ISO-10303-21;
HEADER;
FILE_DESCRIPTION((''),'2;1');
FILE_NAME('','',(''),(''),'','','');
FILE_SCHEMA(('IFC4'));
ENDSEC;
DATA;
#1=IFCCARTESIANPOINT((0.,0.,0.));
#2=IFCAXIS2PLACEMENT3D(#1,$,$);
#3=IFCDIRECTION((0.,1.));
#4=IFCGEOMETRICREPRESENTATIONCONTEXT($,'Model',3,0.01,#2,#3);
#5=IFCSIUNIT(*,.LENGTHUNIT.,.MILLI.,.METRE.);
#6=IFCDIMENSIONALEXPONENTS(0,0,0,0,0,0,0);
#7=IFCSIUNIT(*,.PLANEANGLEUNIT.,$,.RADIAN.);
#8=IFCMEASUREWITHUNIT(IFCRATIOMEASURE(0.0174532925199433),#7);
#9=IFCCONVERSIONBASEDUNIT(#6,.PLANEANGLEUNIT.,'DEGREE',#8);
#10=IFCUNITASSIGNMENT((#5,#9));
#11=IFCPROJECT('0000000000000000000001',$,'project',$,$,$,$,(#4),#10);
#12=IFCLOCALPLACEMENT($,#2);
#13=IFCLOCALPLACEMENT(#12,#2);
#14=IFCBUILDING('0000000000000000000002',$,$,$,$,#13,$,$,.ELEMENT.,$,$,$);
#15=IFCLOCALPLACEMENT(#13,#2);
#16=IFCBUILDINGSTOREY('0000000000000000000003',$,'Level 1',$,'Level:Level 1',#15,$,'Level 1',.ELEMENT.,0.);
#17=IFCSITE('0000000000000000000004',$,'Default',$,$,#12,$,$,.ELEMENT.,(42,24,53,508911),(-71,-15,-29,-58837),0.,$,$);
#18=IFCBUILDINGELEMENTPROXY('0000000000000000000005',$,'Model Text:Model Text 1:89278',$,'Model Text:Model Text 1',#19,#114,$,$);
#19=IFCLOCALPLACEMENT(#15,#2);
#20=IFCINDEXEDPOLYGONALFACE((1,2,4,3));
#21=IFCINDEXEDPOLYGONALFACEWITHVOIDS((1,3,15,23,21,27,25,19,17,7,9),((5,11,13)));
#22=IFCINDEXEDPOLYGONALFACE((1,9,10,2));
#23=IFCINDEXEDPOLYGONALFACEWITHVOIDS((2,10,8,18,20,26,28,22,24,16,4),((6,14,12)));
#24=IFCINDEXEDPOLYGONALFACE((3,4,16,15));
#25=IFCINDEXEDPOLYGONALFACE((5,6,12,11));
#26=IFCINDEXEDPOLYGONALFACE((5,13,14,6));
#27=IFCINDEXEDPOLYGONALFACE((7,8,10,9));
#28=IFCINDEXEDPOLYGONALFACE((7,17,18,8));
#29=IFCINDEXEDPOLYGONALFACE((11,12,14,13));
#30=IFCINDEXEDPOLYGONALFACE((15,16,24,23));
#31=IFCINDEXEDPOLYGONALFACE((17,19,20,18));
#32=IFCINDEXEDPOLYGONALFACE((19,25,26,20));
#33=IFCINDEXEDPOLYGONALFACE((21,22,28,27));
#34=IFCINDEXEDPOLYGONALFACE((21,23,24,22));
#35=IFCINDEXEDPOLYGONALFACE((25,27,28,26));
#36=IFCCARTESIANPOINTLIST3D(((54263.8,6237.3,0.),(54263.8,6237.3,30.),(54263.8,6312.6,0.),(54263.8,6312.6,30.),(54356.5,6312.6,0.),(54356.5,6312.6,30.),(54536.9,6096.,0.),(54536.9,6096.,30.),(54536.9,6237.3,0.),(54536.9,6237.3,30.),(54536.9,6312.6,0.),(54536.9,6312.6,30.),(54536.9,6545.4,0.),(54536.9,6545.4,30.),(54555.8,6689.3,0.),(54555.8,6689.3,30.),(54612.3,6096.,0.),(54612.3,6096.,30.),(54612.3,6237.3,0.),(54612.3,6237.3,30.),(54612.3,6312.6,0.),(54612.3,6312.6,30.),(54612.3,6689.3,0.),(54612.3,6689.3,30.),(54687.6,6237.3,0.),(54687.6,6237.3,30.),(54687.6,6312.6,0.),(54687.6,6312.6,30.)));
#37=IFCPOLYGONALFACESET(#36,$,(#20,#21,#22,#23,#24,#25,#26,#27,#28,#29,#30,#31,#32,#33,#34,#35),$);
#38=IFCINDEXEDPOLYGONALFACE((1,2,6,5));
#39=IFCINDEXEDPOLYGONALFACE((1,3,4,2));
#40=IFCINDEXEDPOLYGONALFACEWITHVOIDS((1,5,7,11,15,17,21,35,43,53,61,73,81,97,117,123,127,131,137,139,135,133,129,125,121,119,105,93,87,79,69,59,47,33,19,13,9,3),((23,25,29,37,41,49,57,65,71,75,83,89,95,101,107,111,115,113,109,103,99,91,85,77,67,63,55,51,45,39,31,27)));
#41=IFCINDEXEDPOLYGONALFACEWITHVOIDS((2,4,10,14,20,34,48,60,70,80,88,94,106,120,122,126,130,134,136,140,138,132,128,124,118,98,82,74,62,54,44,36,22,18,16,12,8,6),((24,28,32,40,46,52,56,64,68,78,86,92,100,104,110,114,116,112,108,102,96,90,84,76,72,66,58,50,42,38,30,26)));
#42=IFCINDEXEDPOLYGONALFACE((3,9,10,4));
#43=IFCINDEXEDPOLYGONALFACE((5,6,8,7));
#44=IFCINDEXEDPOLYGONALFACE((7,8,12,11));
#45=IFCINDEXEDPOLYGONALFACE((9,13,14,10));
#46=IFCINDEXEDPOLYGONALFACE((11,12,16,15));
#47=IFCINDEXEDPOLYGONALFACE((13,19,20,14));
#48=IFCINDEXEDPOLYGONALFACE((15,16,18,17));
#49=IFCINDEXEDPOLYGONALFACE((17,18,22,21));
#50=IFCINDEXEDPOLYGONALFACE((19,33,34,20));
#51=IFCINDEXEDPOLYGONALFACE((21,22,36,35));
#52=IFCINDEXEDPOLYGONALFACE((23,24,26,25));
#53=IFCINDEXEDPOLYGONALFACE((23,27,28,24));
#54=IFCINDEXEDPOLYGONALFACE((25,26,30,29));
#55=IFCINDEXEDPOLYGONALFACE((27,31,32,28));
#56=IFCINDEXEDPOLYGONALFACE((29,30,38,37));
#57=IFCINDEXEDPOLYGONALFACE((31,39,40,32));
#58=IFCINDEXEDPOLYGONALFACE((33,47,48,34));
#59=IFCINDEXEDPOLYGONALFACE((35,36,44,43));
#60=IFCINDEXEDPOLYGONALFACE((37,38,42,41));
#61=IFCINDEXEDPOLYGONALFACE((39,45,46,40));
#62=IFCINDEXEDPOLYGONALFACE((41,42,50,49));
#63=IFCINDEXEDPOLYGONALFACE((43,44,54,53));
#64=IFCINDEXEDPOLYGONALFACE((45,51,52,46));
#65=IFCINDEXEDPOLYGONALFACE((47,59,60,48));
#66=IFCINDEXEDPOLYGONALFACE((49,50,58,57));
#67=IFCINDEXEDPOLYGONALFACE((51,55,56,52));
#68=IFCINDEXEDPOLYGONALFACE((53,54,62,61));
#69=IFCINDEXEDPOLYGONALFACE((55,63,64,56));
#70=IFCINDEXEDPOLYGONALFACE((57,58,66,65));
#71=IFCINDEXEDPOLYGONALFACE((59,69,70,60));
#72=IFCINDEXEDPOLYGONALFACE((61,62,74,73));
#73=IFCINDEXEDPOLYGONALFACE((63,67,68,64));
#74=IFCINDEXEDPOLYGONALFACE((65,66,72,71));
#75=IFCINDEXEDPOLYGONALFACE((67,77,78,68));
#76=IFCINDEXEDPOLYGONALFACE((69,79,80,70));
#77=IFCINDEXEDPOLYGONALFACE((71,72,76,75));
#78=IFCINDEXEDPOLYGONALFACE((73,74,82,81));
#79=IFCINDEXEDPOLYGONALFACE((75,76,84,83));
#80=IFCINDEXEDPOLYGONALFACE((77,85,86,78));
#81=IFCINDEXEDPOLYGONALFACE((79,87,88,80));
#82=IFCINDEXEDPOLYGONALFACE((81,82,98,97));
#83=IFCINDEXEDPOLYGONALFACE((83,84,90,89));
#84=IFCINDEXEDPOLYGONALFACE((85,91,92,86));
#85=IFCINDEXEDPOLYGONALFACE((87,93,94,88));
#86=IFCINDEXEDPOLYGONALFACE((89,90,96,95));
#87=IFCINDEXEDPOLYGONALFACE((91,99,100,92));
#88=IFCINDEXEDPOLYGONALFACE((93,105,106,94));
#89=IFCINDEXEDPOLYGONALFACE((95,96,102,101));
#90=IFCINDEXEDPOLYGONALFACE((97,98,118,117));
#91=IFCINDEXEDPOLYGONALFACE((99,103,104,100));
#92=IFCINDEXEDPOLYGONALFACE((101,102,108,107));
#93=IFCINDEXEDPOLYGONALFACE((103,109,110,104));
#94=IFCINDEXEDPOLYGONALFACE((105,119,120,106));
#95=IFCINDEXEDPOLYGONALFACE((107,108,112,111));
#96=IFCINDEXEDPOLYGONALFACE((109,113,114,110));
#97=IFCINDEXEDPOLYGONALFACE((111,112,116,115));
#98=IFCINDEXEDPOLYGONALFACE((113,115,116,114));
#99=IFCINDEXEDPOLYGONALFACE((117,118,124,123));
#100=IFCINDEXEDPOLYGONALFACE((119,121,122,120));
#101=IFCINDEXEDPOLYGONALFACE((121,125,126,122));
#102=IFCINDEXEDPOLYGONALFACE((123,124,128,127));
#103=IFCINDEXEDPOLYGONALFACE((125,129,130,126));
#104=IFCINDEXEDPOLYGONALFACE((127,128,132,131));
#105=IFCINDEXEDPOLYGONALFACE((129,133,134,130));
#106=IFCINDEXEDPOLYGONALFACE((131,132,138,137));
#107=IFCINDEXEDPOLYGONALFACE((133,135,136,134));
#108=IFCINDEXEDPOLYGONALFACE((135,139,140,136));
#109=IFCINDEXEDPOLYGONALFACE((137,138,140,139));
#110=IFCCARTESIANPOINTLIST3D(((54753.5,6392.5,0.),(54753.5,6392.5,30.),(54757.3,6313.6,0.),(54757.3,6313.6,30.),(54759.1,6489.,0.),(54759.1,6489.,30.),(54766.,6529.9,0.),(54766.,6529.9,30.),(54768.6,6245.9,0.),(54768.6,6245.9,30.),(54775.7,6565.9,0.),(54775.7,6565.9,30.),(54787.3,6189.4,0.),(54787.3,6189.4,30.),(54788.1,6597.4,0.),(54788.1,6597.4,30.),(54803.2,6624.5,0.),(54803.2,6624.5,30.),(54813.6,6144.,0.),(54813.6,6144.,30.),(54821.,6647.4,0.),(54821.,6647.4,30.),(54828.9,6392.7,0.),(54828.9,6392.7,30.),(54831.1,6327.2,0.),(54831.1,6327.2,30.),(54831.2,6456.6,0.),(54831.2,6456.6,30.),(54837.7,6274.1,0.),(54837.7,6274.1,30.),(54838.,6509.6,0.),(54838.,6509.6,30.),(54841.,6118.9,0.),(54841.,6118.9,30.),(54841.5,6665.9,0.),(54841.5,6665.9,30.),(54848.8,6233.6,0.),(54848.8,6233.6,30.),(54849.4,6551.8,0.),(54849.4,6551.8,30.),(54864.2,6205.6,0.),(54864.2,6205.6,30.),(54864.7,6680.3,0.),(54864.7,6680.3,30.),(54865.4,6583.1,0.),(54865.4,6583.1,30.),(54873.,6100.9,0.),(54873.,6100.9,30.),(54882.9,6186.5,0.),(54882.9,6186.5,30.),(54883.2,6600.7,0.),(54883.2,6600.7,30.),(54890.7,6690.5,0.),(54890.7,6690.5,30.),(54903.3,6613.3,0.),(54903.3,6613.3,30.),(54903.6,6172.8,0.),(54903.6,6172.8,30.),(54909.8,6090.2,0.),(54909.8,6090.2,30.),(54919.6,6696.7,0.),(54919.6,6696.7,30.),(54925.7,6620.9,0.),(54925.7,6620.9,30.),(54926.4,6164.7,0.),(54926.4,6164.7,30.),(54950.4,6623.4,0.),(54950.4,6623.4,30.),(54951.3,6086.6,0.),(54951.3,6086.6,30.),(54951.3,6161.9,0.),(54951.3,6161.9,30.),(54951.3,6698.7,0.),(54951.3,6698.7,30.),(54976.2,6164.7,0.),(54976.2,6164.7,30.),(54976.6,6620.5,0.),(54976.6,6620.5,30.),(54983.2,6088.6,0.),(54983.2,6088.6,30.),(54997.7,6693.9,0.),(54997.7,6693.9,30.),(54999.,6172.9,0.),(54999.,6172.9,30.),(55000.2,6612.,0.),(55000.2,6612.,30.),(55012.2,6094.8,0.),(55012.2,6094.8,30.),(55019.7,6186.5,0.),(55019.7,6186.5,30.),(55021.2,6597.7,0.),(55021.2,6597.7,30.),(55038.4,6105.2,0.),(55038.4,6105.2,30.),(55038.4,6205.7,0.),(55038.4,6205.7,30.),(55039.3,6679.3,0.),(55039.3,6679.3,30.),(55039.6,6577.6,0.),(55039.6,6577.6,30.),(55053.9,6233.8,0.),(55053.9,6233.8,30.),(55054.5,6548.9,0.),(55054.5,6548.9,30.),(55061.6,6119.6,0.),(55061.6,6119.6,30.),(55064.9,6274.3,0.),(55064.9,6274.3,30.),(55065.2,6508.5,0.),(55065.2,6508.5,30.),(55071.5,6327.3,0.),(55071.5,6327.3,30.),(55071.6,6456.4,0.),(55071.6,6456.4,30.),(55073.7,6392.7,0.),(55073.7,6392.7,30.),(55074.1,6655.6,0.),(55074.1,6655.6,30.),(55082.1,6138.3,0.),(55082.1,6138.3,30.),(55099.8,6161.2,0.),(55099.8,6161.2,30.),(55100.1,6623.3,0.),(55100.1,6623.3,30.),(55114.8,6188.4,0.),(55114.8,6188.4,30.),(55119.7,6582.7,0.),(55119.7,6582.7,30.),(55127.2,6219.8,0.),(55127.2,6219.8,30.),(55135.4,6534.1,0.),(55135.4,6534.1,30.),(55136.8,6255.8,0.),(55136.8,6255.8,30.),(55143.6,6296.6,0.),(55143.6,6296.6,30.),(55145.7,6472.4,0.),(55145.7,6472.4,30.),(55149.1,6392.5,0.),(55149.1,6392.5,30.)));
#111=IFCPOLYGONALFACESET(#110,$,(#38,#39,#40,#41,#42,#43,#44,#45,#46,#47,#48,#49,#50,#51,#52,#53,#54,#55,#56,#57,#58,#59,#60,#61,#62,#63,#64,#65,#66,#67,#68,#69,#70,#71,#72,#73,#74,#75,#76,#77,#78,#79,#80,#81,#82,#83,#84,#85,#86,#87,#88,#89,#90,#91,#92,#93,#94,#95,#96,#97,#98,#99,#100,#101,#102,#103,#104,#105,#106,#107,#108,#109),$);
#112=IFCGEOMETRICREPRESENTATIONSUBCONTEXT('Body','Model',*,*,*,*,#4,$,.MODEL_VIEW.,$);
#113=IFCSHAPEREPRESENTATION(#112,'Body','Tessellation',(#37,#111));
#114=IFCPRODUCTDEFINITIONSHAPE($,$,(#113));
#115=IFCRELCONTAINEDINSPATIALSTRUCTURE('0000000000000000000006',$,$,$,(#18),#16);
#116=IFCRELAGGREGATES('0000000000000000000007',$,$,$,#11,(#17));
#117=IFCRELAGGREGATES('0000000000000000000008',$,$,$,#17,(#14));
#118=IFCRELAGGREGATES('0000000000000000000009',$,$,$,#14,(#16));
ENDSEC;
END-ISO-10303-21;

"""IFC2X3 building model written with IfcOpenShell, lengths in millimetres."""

from ifc_helpers import new_model, entity, si_unit, converted_unit, direction, frame, origin, place, context, subcontext, project, spatial, polyline, outline, extrude, element, save


model = new_model("IFC2X3")

# Units and contexts
model_context = context("Model", 3, precision=0.01, world=origin(), true_north=direction((0.0, 1.0)))
body_context = subcontext(model_context, "Body", "Model", "MODEL_VIEW")
ifc_project = project(units=[si_unit("LENGTHUNIT", "METRE", prefix="MILLI"), converted_unit("PLANEANGLEUNIT", "DEGREE", entity("IfcRatioMeasure", 0.0174532925199433), si_unit("PLANEANGLEUNIT", "RADIAN"), dimensions=[0, 0, 0, 0, 0, 0, 0])], contexts=[model_context])

# Site, building, storey
site_placement = place(None, origin())
site = spatial("IfcSite", under=ifc_project, at=site_placement, Name="Default", CompositionType="ELEMENT", RefLatitude=(42, 24, 53, 508911), RefLongitude=(-71, -15, -29, -58837), RefElevation=0.0)
building_placement = place(site_placement, origin())
building = spatial("IfcBuilding", under=site, at=building_placement, CompositionType="ELEMENT")
storey_placement = place(building_placement, origin())
storey = spatial("IfcBuildingStorey", under=building, at=storey_placement, Name="Level 1", ObjectType="Level:Level 1", LongName="Level 1", CompositionType="ELEMENT", Elevation=0.0)

# Building element proxy
proxy_1_placement = place(storey_placement, origin())
element("IfcBuildingElementProxy", 1, at=proxy_1_placement, inside=storey, Name="Model Text:Model Text 1:89278", ObjectType="Model Text:Model Text 1", context=body_context, shape_type="SweptSolid", body=[
    extrude(outline(polyline([(-6.8, -218.3), (68.5, -218.3), (68.5, -77.1), (143.8, -77.1), (143.8, -1.7), (68.5, -1.7), (68.5, 375.0), (12.0, 375.0), (-280.0, -1.7), (-280.0, -77.1), (-6.8, -77.1), (-6.8, -218.3)]), holes=[polyline([(-6.8, -1.7), (-187.3, -1.7), (-6.8, 231.1), (-6.8, -1.7)])]), frame((54543.8, 6314.3, 0.0)), (0.0, 0.0, 1.0), 30.0),
    extrude(outline(polyline([(-10.6, -198.7), (68.3, -198.7), (136.5, -190.7), (193.9, -174.7), (240.5, -150.6), (266.9, -124.4), (286.3, -93.2), (298.8, -57.0), (304.3, -15.7), (303.8, 16.2), (299.0, 45.5), (289.9, 72.1), (276.6, 96.0), (258.9, 117.3), (236.9, 136.2), (210.4, 152.5), (179.6, 166.3), (144.1, 177.6), (103.7, 186.3), (8.2, 196.4), (-71.8, 196.7), (-134.0, 189.4), (-183.3, 176.1), (-224.7, 158.4), (-258.2, 133.9), (-283.5, 100.3), (-300.1, 59.5), (-307.1, 13.4), (-306.6, -18.4), (-301.8, -47.5), (-292.8, -74.0), (-279.6, -97.9), (-262.0, -119.2), (-240.0, -138.1), (-213.6, -154.5), (-182.8, -168.4), (-147.3, -179.8), (-106.7, -188.6), (-10.6, -198.7)]), holes=[polyline([(-7.2, -123.5), (-71.0, -118.2), (-123.6, -108.8), (-165.2, -95.4), (-195.7, -78.0), (-212.4, -59.4), (-224.1, -38.7), (-230.6, -15.9), (-231.9, 8.9), (-227.8, 35.0), (-218.1, 58.1), (-202.8, 78.4), (-182.0, 95.8), (-152.6, 109.4), (-111.7, 118.1), (-59.4, 122.0), (4.4, 121.1), (69.6, 115.8), (122.2, 106.7), (162.2, 93.7), (189.5, 77.0), (207.7, 57.4), (220.4, 36.0), (227.5, 12.8), (229.1, -12.1), (225.2, -36.8), (215.9, -59.2), (201.3, -79.3), (181.4, -97.1), (152.6, -111.2), (111.6, -120.3), (58.3, -124.4), (-7.2, -123.5)])]), frame((54952.6, 6391.3, 0.0), z_axis=(0.0, 0.0, 1.0), x_axis=(0.047515, -0.998871, 0.0)), (0.0, 0.0, 1.0), 30.0),
])

save(model, "model.ifc")
